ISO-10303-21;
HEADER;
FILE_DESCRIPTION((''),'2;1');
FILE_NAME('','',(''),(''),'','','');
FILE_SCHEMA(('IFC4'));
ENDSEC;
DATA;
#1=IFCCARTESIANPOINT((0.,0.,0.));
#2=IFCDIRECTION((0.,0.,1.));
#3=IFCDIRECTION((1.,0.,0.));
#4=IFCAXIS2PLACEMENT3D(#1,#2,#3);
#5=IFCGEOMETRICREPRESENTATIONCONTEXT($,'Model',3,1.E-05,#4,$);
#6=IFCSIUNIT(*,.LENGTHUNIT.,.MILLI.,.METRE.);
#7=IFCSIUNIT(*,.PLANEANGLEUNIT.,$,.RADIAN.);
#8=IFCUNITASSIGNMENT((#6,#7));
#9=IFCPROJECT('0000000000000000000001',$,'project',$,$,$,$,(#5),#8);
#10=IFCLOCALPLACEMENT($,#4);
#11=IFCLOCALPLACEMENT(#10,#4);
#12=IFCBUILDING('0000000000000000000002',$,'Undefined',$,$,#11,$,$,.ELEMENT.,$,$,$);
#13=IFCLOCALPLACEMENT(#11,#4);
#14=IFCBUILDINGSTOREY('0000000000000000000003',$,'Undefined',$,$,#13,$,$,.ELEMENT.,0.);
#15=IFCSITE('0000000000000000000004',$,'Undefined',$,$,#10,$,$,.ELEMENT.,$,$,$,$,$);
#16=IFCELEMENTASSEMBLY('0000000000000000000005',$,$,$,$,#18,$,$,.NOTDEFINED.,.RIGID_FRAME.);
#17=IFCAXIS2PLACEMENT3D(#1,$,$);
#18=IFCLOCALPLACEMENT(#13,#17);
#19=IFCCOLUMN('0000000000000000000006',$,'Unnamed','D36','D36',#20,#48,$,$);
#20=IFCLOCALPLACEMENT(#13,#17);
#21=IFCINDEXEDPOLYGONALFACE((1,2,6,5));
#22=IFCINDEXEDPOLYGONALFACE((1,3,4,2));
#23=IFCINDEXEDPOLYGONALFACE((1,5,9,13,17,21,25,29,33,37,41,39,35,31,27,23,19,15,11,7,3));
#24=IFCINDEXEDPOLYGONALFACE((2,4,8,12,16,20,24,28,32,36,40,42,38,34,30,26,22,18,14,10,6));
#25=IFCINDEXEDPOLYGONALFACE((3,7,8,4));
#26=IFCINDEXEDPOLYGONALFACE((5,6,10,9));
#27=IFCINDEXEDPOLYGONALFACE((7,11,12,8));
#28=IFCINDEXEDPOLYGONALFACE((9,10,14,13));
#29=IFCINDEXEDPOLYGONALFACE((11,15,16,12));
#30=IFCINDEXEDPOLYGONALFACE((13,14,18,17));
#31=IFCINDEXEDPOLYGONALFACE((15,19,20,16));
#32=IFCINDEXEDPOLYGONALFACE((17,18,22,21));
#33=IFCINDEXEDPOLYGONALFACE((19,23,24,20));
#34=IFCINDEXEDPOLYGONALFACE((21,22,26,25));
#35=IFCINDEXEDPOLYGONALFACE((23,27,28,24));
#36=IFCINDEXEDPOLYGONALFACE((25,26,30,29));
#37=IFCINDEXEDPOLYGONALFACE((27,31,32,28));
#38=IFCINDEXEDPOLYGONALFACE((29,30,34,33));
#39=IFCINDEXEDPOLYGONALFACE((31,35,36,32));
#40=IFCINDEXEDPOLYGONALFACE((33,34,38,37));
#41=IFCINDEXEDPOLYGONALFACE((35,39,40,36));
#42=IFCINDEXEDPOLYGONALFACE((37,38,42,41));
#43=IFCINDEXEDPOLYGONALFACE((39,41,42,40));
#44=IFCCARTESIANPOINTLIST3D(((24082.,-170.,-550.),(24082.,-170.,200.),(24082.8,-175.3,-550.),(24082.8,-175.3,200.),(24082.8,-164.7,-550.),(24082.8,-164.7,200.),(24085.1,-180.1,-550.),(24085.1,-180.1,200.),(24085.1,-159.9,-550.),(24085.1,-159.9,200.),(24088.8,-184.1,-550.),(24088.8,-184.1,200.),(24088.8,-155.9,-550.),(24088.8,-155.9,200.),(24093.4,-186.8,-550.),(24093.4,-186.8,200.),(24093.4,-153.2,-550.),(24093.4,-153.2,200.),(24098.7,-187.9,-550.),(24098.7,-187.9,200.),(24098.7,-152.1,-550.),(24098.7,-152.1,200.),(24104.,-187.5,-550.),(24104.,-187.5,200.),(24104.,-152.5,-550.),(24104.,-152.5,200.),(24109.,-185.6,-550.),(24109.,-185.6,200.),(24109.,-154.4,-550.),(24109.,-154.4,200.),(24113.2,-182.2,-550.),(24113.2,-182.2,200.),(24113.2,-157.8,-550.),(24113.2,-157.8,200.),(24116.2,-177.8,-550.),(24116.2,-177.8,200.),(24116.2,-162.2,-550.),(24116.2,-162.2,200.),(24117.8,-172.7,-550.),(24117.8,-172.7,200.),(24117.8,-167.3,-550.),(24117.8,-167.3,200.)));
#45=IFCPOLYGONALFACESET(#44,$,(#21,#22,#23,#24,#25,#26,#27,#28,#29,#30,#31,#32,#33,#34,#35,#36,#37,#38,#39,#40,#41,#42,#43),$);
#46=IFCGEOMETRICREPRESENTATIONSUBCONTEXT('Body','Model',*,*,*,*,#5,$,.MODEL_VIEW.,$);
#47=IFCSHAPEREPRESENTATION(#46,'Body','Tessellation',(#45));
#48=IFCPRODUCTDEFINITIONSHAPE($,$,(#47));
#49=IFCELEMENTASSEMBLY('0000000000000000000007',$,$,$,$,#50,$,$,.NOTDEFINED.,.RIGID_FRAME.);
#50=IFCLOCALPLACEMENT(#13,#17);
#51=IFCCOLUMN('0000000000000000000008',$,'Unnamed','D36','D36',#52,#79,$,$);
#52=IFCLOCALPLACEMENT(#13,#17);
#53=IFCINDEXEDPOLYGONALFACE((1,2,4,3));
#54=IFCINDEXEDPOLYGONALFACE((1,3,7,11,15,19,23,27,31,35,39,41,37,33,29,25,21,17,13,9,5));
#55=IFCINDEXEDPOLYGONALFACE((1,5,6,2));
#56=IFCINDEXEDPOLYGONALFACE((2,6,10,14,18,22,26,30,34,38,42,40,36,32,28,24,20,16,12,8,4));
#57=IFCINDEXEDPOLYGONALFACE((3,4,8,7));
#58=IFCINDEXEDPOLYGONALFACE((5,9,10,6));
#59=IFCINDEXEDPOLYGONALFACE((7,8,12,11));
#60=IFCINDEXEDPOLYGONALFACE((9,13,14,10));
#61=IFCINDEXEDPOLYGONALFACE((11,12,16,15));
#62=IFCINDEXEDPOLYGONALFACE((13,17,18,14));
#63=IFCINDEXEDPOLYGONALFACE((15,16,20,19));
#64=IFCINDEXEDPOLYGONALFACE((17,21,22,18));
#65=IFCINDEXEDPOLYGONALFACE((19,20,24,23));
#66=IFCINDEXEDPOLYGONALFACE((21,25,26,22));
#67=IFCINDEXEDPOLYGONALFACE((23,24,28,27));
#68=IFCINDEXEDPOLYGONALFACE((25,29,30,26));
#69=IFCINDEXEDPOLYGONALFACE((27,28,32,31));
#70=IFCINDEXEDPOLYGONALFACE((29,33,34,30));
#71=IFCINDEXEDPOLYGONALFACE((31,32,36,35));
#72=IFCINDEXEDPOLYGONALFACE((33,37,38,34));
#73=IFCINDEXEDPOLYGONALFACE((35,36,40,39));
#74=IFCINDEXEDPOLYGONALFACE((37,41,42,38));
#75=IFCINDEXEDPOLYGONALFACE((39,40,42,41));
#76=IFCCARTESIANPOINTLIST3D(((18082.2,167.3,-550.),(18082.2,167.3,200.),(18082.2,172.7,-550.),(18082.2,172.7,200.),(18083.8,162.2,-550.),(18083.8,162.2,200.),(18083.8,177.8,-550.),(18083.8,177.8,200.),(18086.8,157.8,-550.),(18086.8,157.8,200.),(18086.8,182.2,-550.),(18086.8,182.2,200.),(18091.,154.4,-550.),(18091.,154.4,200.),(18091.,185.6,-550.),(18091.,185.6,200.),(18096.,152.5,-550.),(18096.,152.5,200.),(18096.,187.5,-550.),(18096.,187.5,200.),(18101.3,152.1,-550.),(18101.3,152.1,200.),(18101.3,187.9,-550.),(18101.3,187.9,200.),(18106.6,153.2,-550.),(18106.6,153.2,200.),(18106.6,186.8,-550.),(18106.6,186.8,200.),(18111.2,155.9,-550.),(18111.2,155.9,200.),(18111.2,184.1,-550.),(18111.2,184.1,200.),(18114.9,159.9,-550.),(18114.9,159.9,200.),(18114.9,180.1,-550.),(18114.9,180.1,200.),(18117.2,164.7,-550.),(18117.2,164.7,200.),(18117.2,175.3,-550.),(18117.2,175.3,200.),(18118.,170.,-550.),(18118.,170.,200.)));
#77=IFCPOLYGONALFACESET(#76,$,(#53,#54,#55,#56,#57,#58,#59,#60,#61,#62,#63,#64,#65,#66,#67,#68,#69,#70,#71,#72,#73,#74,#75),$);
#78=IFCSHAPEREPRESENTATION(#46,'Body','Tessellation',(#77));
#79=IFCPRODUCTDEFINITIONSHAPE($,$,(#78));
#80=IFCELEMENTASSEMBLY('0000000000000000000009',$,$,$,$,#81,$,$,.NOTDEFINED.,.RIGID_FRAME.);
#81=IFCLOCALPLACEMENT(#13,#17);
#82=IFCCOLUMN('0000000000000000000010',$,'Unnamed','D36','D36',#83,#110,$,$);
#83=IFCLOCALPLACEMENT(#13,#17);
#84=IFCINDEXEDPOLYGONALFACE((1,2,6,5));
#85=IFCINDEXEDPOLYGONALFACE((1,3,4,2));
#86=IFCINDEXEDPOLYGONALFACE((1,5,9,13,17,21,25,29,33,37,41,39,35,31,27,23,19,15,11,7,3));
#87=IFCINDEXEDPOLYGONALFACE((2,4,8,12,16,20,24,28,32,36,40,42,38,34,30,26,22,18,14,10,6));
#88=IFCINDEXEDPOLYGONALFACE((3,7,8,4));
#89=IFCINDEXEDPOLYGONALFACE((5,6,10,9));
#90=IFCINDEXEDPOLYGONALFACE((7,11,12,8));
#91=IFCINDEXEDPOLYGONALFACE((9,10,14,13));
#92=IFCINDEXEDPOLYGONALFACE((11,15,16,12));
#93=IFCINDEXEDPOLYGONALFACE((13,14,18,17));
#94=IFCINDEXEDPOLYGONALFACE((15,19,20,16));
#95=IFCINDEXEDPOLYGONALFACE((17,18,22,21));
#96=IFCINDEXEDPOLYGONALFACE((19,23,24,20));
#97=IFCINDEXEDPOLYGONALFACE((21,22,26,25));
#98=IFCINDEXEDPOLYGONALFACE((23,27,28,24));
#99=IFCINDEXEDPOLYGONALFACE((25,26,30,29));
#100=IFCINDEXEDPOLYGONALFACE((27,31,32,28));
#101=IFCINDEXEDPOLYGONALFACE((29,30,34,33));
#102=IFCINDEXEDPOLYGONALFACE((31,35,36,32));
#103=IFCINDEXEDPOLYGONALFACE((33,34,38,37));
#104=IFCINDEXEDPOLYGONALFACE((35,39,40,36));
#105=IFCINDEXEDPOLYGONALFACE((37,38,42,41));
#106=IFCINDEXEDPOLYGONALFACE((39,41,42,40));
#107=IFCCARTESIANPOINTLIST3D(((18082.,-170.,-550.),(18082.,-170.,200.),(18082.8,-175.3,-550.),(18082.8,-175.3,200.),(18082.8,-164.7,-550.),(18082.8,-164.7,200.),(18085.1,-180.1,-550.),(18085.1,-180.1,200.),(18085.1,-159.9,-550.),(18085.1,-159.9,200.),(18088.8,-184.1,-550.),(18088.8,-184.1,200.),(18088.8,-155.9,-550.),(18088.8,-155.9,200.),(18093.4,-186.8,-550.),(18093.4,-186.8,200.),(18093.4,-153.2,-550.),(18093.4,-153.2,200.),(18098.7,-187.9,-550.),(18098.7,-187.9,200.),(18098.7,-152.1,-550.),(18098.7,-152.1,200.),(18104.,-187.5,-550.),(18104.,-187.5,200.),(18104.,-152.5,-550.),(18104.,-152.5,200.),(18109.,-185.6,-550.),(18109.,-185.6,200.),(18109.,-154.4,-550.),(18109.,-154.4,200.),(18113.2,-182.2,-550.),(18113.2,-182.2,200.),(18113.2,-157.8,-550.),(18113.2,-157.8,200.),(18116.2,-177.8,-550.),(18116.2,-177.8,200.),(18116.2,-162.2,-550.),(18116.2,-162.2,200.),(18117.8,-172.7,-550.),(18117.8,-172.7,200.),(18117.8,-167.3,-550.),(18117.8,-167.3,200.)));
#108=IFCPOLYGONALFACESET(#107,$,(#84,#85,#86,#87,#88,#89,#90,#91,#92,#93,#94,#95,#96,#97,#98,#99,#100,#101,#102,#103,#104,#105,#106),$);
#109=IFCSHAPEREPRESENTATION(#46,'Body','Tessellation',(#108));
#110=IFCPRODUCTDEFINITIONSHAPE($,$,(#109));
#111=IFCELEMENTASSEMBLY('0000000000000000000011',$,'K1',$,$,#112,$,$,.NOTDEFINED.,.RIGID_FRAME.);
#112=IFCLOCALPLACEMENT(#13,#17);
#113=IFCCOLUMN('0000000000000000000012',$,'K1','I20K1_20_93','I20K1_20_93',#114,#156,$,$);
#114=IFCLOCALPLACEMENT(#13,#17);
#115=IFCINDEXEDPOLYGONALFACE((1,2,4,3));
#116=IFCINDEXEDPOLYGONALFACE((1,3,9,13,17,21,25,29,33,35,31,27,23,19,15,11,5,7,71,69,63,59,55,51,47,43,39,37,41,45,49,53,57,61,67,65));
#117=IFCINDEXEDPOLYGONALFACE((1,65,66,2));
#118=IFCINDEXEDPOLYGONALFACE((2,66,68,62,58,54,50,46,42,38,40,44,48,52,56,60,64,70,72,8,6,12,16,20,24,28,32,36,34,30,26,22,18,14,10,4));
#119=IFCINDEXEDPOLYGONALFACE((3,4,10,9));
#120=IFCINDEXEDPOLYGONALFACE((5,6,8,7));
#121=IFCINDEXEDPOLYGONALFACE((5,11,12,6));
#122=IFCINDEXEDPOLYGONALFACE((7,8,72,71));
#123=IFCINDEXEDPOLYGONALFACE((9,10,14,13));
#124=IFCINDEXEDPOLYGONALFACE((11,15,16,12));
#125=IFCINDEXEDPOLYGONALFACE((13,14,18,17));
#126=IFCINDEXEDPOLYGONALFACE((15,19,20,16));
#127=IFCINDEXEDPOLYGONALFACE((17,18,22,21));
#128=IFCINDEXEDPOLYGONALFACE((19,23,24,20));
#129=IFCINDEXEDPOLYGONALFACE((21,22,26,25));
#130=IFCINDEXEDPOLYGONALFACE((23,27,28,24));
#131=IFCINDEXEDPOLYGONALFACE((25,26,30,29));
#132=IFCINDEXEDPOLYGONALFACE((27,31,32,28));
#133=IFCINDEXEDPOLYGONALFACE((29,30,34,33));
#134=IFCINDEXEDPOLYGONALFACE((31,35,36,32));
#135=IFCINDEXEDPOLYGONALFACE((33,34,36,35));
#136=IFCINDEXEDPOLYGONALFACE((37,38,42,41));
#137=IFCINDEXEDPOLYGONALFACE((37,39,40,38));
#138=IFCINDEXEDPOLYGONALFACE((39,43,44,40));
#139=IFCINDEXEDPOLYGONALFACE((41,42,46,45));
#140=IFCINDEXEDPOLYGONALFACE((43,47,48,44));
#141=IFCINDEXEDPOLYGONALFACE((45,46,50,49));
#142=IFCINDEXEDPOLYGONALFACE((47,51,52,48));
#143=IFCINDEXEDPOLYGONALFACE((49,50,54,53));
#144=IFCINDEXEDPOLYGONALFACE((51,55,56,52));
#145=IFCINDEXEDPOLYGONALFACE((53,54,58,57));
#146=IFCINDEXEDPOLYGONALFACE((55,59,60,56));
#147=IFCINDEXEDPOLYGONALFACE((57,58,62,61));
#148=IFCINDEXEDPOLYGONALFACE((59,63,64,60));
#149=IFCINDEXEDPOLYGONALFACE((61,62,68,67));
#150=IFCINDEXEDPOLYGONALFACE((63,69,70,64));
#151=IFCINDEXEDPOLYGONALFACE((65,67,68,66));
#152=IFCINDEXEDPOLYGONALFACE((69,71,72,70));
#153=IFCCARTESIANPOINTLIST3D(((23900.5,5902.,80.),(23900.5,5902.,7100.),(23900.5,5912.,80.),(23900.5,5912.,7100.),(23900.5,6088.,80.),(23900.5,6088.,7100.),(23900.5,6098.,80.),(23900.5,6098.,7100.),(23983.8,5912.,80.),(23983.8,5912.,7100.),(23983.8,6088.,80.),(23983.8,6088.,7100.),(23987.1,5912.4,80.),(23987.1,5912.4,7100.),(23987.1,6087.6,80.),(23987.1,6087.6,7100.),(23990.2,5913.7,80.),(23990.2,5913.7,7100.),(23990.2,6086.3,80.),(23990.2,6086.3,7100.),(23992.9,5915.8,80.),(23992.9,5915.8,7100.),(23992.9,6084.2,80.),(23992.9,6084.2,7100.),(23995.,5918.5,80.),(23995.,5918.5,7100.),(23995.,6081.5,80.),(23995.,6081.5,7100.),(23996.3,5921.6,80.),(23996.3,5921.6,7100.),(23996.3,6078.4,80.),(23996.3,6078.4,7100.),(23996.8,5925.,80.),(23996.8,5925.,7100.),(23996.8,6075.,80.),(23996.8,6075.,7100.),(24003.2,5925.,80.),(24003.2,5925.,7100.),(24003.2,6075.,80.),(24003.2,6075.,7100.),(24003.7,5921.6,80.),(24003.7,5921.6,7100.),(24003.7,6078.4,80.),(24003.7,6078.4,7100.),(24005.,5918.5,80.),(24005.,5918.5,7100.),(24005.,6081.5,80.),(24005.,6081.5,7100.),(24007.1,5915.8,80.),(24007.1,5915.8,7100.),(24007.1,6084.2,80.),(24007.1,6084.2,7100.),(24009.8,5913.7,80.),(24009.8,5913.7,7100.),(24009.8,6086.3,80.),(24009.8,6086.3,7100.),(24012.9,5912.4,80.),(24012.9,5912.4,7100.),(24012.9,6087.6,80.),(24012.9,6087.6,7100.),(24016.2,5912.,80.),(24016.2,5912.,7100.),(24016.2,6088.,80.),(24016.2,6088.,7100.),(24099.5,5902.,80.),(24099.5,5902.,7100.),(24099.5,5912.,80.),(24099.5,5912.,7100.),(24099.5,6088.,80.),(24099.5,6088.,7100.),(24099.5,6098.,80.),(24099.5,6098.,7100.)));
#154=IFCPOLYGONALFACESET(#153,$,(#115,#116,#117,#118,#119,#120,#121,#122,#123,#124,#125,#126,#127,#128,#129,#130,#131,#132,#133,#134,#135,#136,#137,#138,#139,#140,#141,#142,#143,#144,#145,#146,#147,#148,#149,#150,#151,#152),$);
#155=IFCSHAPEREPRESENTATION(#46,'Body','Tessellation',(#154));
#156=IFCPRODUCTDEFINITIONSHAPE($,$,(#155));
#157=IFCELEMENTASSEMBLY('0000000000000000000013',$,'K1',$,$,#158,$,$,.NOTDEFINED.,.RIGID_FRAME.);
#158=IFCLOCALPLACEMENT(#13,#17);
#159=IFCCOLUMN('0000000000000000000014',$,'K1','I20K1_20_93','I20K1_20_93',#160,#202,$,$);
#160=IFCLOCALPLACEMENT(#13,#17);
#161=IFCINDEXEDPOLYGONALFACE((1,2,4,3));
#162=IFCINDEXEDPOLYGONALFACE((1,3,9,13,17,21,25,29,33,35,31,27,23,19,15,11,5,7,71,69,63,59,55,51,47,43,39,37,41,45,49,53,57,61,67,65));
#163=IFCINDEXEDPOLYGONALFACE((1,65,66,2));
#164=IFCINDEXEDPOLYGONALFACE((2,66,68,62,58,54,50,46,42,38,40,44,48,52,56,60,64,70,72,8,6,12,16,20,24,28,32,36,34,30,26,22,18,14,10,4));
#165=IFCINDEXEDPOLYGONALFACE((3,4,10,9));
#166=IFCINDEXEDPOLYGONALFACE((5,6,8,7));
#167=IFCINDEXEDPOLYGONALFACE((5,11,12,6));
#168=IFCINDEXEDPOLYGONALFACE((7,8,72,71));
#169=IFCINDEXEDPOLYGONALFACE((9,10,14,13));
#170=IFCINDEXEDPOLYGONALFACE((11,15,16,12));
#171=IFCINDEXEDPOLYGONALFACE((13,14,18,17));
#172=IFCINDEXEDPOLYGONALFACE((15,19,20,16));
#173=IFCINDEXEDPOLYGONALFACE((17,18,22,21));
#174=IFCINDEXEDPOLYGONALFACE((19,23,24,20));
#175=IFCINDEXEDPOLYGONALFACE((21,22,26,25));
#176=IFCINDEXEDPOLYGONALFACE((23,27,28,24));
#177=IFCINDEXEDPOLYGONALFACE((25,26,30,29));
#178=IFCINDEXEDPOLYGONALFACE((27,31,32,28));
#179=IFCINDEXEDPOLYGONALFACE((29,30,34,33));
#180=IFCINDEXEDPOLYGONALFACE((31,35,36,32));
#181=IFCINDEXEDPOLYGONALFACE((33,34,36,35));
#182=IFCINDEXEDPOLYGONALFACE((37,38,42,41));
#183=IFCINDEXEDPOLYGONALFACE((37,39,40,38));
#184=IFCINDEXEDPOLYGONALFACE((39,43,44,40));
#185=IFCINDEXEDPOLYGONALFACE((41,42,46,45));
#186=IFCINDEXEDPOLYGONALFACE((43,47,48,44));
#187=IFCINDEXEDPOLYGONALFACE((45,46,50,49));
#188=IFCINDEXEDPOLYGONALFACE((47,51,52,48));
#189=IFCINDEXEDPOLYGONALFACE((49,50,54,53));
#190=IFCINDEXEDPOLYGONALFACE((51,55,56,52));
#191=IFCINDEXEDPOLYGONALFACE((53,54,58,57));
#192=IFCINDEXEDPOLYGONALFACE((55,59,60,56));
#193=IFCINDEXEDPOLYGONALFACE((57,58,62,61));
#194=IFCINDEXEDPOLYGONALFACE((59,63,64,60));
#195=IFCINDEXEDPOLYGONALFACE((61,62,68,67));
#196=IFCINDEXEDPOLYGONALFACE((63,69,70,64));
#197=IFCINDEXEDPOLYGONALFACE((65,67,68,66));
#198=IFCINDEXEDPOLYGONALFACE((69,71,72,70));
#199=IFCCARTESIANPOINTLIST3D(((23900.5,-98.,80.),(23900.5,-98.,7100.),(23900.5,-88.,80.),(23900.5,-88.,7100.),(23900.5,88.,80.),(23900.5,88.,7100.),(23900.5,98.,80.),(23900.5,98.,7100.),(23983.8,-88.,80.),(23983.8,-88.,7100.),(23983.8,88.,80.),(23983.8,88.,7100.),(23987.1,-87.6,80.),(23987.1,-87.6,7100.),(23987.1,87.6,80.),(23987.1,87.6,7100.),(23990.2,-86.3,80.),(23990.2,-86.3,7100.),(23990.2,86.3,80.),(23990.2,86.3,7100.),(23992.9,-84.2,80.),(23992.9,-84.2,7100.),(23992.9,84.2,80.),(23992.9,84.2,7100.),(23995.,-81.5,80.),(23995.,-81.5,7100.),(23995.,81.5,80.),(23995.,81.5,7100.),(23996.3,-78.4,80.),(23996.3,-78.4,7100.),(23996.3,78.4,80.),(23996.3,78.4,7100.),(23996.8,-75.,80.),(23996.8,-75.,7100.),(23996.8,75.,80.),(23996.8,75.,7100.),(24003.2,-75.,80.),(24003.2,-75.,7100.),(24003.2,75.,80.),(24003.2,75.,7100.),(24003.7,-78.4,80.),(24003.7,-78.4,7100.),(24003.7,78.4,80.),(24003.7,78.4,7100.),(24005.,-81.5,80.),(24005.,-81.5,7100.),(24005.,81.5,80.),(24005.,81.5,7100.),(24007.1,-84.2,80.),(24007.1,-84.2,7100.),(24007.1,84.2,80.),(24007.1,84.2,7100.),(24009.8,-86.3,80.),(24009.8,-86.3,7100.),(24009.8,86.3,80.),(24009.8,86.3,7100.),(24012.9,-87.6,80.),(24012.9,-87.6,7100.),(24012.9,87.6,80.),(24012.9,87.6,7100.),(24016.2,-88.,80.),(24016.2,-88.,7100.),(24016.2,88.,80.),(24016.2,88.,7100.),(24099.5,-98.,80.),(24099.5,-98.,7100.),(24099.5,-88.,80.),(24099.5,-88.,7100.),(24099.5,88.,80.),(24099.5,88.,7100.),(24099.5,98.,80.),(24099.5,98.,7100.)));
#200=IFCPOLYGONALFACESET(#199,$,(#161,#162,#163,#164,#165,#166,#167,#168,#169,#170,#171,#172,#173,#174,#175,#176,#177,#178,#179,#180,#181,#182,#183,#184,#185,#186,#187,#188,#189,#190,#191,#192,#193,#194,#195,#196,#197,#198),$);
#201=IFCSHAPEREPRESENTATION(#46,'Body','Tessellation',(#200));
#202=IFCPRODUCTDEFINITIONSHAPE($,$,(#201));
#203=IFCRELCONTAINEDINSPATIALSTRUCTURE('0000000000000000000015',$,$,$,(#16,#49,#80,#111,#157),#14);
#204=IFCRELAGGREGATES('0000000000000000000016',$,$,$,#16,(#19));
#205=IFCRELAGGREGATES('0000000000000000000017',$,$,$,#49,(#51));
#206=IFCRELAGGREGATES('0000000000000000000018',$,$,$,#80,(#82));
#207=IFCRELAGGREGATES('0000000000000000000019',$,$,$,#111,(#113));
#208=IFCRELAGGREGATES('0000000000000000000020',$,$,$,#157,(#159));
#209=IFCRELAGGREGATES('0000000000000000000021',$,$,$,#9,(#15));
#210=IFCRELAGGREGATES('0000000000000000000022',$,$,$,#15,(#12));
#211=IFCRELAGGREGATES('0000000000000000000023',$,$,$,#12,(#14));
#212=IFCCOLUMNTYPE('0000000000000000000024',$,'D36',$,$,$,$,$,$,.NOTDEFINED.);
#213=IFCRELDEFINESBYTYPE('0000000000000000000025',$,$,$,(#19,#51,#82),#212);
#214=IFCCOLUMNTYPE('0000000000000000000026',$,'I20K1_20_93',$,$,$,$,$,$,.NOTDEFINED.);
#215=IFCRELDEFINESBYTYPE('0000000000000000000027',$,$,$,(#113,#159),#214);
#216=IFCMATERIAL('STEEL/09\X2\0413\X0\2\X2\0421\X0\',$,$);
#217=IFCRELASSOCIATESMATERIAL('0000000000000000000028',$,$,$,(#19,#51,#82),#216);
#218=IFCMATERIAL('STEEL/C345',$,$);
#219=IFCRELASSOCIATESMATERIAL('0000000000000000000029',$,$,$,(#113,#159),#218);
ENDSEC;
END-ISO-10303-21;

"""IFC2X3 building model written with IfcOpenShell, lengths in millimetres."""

from ifc_helpers import new_model, si_unit, frame, origin_with_axes, origin_2d_with_axis, place, context, subcontext, project, spatial, circle, i_section, extrude, material, type_object, element, aggregate, save


model = new_model("IFC2X3")

# Units and contexts
model_context = context("Model", 3, precision=1e-05, world=origin_with_axes())
body_context = subcontext(model_context, "Body", "Model", "MODEL_VIEW")
ifc_project = project(units=[si_unit("LENGTHUNIT", "METRE", prefix="MILLI"), si_unit("PLANEANGLEUNIT", "RADIAN")], contexts=[model_context])

# Site, building, storey
site_placement = place(None, origin_with_axes())
site = spatial("IfcSite", under=ifc_project, at=site_placement, Name="Undefined", CompositionType="ELEMENT")
building_placement = place(site_placement, origin_with_axes())
building = spatial("IfcBuilding", under=site, at=building_placement, Name="Undefined", CompositionType="ELEMENT")
storey_placement = place(building_placement, origin_with_axes())
storey = spatial("IfcBuildingStorey", under=building, at=storey_placement, Name="Undefined", CompositionType="ELEMENT", Elevation=0.0)

# Element assemblies, columns
ifc_material_1 = material(Name="STEEL/09Г2С")
column_type_1 = type_object("IfcColumnType", Name="D36", PredefinedType="NOTDEFINED")
assembly_1_placement = place(storey_placement, origin_with_axes())
assembly_1 = element("IfcElementAssembly", 1, at=assembly_1_placement, inside=storey, AssemblyPlace="NOTDEFINED", PredefinedType="RIGID_FRAME")
column_1_placement = place(assembly_1_placement, frame((24100.0, -170.0, -550.0), z_axis=(0.0, 0.0, 1.0), x_axis=(0.0, 1.0, 0.0)))
column_1 = element("IfcColumn", 2, at=column_1_placement, type_object=column_type_1, material=ifc_material_1, Name="Unnamed", Description="D36", ObjectType="D36", context=body_context, shape_type="SweptSolid", body=[
    extrude(circle(Radius=18.0, at=origin_2d_with_axis()), frame((0.0, 0.0, 750.0), z_axis=(0.0, 0.0, -1.0), x_axis=(0.0, 1.0, 0.0)), (0.0, 0.0, 1.0), 750.0),
])
aggregate(assembly_1, [column_1])
assembly_2_placement = place(storey_placement, origin_with_axes())
assembly_2 = element("IfcElementAssembly", 3, at=assembly_2_placement, inside=storey, AssemblyPlace="NOTDEFINED", PredefinedType="RIGID_FRAME")
column_2_placement = place(assembly_2_placement, frame((18100.0, 170.0, -550.0), z_axis=(0.0, 0.0, 1.0), x_axis=(0.0, -1.0, 0.0)))
column_2 = element("IfcColumn", 4, at=column_2_placement, type_object=column_type_1, material=ifc_material_1, Name="Unnamed", Description="D36", ObjectType="D36", context=body_context, shape_type="SweptSolid", body=[
    extrude(circle(Radius=18.0, at=origin_2d_with_axis()), frame((0.0, 0.0, 750.0), z_axis=(0.0, 0.0, -1.0), x_axis=(0.0, 1.0, 0.0)), (0.0, 0.0, 1.0), 750.0),
])
aggregate(assembly_2, [column_2])
assembly_3_placement = place(storey_placement, origin_with_axes())
assembly_3 = element("IfcElementAssembly", 5, at=assembly_3_placement, inside=storey, AssemblyPlace="NOTDEFINED", PredefinedType="RIGID_FRAME")
column_3_placement = place(assembly_3_placement, frame((18100.0, -170.0, -550.0), z_axis=(0.0, 0.0, 1.0), x_axis=(0.0, 1.0, 0.0)))
column_3 = element("IfcColumn", 6, at=column_3_placement, type_object=column_type_1, material=ifc_material_1, Name="Unnamed", Description="D36", ObjectType="D36", context=body_context, shape_type="SweptSolid", body=[
    extrude(circle(Radius=18.0, at=origin_2d_with_axis()), frame((0.0, 0.0, 750.0), z_axis=(0.0, 0.0, -1.0), x_axis=(0.0, 1.0, 0.0)), (0.0, 0.0, 1.0), 750.0),
])
aggregate(assembly_3, [column_3])
assembly_4_placement = place(storey_placement, origin_with_axes())
assembly_4 = element("IfcElementAssembly", 7, at=assembly_4_placement, inside=storey, Name="K1", AssemblyPlace="NOTDEFINED", PredefinedType="RIGID_FRAME")
ifc_material_2 = material(Name="STEEL/C345")
column_type_2 = type_object("IfcColumnType", Name="I20K1_20_93", PredefinedType="NOTDEFINED")
column_4_placement = place(assembly_4_placement, frame((24000.0, 6000.0, 80.0), z_axis=(0.0, 0.0, 1.0), x_axis=(0.0, 1.0, 0.0)))
column_4 = element("IfcColumn", 8, at=column_4_placement, type_object=column_type_2, material=ifc_material_2, Name="K1", Description="I20K1_20_93", ObjectType="I20K1_20_93", context=body_context, shape_type="SweptSolid", body=[
    extrude(i_section(OverallWidth=199.0, OverallDepth=196.0, WebThickness=6.5, FlangeThickness=10.0, FilletRadius=13.0, at=origin_2d_with_axis()), frame((0.0, 0.0, 7020.0), z_axis=(0.0, 0.0, -1.0), x_axis=(0.0, 1.0, 0.0)), (0.0, 0.0, 1.0), 7020.0),
])
assembly_5_placement = place(storey_placement, origin_with_axes())
assembly_5 = element("IfcElementAssembly", 9, at=assembly_5_placement, inside=storey, Name="K1", AssemblyPlace="NOTDEFINED", PredefinedType="RIGID_FRAME")
column_5_placement = place(assembly_5_placement, frame((24000.0, 0.0, 80.0), z_axis=(0.0, 0.0, 1.0), x_axis=(0.0, 1.0, 0.0)))
column_5 = element("IfcColumn", 10, at=column_5_placement, type_object=column_type_2, material=ifc_material_2, Name="K1", Description="I20K1_20_93", ObjectType="I20K1_20_93", context=body_context, shape_type="SweptSolid", body=[
    extrude(i_section(OverallWidth=199.0, OverallDepth=196.0, WebThickness=6.5, FlangeThickness=10.0, FilletRadius=13.0, at=origin_2d_with_axis()), frame((0.0, 0.0, 7020.0), z_axis=(0.0, 0.0, -1.0), x_axis=(0.0, 1.0, 0.0)), (0.0, 0.0, 1.0), 7020.0),
])

aggregate(assembly_4, [column_4])
aggregate(assembly_5, [column_5])

save(model, "model.ifc")
